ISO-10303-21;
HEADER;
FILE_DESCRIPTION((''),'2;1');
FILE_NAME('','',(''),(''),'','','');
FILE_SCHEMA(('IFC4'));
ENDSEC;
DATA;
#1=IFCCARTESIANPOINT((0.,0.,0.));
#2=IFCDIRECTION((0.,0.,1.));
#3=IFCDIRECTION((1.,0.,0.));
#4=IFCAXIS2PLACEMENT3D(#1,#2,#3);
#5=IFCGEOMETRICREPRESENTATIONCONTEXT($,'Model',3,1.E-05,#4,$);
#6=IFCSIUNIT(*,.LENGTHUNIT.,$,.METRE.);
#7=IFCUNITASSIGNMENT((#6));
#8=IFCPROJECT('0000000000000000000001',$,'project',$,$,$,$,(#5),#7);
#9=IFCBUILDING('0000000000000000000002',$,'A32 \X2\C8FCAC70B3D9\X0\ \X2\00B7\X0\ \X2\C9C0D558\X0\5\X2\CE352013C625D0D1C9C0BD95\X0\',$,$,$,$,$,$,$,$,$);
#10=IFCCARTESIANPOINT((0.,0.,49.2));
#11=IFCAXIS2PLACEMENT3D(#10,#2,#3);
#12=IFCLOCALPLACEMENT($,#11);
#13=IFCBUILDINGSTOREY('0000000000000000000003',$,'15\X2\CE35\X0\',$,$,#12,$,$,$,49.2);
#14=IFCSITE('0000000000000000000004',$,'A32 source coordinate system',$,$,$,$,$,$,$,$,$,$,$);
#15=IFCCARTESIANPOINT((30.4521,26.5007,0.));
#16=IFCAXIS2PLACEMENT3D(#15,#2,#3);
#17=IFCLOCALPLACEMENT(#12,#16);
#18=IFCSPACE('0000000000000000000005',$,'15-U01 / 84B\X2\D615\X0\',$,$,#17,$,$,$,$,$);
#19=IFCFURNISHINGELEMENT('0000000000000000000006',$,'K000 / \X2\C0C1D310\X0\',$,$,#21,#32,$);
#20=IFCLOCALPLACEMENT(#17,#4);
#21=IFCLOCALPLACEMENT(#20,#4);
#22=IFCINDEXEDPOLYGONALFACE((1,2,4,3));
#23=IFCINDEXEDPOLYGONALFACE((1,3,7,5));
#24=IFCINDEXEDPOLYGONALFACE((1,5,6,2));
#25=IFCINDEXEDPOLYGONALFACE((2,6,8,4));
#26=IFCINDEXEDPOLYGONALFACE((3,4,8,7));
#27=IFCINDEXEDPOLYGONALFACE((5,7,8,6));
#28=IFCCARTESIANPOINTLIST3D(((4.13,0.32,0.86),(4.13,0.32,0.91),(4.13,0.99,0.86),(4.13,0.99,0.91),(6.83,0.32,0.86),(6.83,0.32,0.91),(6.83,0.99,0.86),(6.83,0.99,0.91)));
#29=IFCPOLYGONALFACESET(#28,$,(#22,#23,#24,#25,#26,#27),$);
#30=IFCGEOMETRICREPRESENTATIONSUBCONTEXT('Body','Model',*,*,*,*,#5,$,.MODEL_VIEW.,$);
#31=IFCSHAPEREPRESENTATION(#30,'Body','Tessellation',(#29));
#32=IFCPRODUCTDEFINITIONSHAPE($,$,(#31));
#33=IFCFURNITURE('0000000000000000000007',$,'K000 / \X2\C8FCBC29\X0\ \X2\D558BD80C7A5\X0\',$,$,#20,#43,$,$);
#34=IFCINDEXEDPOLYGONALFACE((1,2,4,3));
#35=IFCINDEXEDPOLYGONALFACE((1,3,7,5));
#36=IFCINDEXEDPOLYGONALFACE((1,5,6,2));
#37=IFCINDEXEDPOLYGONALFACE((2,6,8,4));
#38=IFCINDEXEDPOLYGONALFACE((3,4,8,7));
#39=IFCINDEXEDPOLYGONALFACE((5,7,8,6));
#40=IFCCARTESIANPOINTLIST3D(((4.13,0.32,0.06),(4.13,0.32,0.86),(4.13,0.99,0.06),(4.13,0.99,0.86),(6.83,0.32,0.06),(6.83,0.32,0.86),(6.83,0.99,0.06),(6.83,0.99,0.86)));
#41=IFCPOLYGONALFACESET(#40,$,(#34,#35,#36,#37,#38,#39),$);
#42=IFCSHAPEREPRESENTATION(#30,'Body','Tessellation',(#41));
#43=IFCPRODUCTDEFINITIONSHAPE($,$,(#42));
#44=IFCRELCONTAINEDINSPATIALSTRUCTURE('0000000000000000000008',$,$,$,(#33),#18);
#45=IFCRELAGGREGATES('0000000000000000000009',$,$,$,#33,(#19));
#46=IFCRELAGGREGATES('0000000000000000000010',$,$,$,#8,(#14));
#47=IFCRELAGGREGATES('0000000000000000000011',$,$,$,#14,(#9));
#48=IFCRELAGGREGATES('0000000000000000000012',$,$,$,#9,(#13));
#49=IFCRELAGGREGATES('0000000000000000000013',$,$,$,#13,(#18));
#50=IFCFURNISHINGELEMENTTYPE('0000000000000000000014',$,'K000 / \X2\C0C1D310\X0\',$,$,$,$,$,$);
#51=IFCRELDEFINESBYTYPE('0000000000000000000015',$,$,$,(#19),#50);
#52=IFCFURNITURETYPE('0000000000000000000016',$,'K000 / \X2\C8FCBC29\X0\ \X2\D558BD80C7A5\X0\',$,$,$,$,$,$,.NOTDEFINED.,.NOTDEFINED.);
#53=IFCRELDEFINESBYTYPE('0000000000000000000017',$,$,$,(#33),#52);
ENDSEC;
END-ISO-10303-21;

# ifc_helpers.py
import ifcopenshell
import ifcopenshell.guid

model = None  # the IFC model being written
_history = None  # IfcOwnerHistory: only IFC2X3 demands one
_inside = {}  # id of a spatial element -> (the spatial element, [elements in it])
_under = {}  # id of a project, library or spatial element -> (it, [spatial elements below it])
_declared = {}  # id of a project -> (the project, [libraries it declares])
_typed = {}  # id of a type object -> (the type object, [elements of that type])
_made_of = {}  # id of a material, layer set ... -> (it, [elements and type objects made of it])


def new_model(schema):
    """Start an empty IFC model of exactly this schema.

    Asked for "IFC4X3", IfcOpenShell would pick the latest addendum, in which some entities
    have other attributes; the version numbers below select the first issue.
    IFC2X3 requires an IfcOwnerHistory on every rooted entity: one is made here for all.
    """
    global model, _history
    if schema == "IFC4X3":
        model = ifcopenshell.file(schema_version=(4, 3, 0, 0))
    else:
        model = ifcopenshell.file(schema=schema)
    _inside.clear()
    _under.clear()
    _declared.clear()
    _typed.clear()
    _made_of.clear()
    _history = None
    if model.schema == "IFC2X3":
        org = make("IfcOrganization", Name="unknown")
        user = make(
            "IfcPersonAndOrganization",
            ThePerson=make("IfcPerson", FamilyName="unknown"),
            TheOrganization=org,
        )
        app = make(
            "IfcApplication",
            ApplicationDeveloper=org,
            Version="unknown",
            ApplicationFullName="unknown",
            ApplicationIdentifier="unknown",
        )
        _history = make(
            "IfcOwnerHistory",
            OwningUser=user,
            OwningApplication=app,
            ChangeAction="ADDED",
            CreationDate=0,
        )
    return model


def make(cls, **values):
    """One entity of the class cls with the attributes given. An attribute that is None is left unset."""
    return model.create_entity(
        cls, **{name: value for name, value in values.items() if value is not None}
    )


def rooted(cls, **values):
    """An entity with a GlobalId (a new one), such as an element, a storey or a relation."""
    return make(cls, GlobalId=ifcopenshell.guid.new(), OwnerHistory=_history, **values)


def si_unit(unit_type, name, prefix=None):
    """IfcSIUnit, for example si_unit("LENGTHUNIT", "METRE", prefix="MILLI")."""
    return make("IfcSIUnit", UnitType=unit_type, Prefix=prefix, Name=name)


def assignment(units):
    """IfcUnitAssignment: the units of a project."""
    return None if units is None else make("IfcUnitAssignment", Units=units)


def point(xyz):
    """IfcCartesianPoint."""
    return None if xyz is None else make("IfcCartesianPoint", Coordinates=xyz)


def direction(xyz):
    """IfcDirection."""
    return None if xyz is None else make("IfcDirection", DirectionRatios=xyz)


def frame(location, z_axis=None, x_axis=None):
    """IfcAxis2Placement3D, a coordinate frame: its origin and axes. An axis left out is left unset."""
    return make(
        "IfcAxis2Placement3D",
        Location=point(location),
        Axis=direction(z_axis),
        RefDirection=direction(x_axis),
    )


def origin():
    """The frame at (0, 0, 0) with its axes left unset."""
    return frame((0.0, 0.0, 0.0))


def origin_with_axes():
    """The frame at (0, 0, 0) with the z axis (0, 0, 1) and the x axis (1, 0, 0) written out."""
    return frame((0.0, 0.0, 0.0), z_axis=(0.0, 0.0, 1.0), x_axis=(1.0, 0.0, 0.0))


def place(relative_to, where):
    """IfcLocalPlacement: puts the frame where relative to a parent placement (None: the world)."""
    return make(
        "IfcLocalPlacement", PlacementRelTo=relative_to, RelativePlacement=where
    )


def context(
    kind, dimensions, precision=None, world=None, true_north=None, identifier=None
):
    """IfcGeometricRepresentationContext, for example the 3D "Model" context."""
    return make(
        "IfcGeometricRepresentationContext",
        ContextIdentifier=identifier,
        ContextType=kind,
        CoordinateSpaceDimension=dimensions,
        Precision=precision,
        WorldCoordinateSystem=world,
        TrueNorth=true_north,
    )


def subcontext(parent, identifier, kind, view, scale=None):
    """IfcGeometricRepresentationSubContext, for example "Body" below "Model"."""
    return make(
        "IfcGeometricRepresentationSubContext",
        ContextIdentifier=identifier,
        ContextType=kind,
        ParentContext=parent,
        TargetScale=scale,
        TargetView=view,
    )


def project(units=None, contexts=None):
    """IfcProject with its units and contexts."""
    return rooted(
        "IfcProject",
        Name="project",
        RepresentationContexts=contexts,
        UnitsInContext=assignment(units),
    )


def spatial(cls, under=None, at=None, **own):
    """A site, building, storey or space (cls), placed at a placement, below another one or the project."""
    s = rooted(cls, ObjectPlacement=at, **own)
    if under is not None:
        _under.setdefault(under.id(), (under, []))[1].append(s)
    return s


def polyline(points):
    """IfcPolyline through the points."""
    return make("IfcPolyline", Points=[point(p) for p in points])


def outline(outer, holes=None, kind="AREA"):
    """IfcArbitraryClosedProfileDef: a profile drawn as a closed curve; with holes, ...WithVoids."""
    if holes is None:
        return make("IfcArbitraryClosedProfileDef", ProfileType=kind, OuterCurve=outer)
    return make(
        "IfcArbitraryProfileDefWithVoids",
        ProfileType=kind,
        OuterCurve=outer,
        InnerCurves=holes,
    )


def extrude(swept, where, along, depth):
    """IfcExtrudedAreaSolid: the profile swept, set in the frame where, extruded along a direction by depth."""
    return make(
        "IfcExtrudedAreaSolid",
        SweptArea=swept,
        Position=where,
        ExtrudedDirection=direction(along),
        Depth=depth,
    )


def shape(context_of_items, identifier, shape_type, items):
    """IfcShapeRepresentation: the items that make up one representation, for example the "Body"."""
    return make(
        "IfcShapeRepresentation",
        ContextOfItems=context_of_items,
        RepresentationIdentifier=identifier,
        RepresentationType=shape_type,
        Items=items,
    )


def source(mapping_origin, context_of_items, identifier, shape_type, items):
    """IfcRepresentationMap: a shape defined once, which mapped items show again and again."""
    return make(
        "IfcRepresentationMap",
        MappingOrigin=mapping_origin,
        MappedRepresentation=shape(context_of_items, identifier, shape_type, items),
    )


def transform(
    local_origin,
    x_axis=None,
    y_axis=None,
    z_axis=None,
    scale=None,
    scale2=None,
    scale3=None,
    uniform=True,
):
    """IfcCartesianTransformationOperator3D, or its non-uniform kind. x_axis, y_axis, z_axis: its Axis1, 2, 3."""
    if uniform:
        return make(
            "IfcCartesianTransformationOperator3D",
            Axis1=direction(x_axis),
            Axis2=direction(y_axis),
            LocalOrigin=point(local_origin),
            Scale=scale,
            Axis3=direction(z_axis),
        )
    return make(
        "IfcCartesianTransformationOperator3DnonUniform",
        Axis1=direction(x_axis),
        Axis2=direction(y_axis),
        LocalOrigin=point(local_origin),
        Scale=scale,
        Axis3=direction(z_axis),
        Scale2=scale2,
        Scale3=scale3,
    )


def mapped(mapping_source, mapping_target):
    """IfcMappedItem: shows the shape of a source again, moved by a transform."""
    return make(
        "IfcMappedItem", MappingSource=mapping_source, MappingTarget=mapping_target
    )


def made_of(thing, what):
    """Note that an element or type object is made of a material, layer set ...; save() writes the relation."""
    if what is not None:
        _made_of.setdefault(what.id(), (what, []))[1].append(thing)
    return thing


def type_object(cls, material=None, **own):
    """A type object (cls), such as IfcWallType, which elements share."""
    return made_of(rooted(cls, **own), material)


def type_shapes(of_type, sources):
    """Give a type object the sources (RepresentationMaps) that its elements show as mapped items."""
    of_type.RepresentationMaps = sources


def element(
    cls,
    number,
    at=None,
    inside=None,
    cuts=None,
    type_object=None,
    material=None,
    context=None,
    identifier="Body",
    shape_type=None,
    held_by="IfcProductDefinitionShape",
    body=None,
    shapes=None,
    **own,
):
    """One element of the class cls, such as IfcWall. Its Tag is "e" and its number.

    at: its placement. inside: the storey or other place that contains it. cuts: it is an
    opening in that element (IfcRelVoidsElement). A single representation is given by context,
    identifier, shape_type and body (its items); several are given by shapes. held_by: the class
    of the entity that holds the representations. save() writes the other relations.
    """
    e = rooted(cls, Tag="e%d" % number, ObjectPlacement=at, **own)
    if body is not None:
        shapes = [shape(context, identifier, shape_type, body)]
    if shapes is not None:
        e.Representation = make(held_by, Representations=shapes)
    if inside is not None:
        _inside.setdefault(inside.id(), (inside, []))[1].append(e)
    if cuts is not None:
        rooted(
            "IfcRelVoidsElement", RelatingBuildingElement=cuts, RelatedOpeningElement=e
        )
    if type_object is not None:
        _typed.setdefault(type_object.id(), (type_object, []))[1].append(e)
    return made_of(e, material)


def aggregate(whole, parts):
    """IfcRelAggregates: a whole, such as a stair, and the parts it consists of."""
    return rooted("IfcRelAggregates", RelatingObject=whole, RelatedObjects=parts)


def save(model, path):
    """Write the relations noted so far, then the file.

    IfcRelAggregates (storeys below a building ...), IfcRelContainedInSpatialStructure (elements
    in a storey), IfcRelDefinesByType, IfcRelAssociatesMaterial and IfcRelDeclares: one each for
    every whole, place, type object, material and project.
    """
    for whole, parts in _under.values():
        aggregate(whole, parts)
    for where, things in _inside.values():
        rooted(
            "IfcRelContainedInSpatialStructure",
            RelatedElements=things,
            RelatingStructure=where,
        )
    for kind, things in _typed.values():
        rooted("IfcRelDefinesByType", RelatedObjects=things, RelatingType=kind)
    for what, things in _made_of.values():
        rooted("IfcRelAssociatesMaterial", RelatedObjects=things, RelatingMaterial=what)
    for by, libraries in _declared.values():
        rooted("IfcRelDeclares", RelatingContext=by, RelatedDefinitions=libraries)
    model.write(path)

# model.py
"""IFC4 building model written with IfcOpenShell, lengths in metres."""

from ifc_helpers import new_model, si_unit, frame, origin, origin_with_axes, place, context, subcontext, project, spatial, polyline, outline, extrude, source, transform, mapped, type_object, type_shapes, element, aggregate, save


model = new_model("IFC4")

# Units and contexts
model_context = context("Model", 3, precision=1e-05, world=origin_with_axes())
body_context = subcontext(model_context, "Body", "Model", "MODEL_VIEW")
ifc_project = project(units=[si_unit("LENGTHUNIT", "METRE")], contexts=[model_context])

# Site, building, storey, space
site = spatial("IfcSite", under=ifc_project, Name="A32 source coordinate system")
building = spatial("IfcBuilding", under=site, Name="A32 주거동 · 지하5층–옥탑지붕")
storey_placement = place(None, frame((0.0, 0.0, 49.2), z_axis=(0.0, 0.0, 1.0), x_axis=(1.0, 0.0, 0.0)))
storey = spatial("IfcBuildingStorey", under=building, at=storey_placement, Name="15층", Elevation=49.2)
space_placement = place(storey_placement, frame((30.4521, 26.5007, 0.0), z_axis=(0.0, 0.0, 1.0), x_axis=(1.0, 0.0, 0.0)))
space = spatial("IfcSpace", under=storey, at=space_placement, Name="15-U01 / 84B형")

# Furnishing element
furnishing_element_type = type_object("IfcFurnishingElementType", Name="K000 / 상판")
shared_shape_1 = source(origin(), body_context, "Body", "SweptSolid", [
    extrude(outline(polyline([(4.13, 0.32), (4.13, 0.99), (6.83, 0.99), (6.83, 0.32), (4.13, 0.32)])), frame((0.0, 0.0, 0.86)), (0.0, 0.0, 1.0), 0.05),
])
type_shapes(furnishing_element_type, [shared_shape_1])
furniture_placement = place(space_placement, origin_with_axes())
furnishing_placement = place(furniture_placement, origin_with_axes())
furnishing = element("IfcFurnishingElement", 1, at=furnishing_placement, type_object=furnishing_element_type, Name="K000 / 상판", context=body_context, shape_type="MappedRepresentation", body=[
    mapped(shared_shape_1, transform((0.0, 0.0, 0.0), scale=1.0)),
])

# Furniture
furniture_type = type_object("IfcFurnitureType", Name="K000 / 주방 하부장", AssemblyPlace="NOTDEFINED", PredefinedType="NOTDEFINED")
shared_shape_2 = source(origin(), body_context, "Body", "SweptSolid", [
    extrude(outline(polyline([(6.83, 0.32), (4.13, 0.32), (4.13, 0.99), (6.83, 0.99), (6.83, 0.32)])), frame((0.0, 0.0, 0.06)), (0.0, 0.0, 1.0), 0.8),
])
type_shapes(furniture_type, [shared_shape_2])
furniture = element("IfcFurniture", 2, at=furniture_placement, inside=space, type_object=furniture_type, Name="K000 / 주방 하부장", context=body_context, shape_type="MappedRepresentation", body=[
    mapped(shared_shape_2, transform((0.0, 0.0, 0.0), scale=1.0)),
])
aggregate(furniture, [furnishing])

save(model, "model.ifc")
